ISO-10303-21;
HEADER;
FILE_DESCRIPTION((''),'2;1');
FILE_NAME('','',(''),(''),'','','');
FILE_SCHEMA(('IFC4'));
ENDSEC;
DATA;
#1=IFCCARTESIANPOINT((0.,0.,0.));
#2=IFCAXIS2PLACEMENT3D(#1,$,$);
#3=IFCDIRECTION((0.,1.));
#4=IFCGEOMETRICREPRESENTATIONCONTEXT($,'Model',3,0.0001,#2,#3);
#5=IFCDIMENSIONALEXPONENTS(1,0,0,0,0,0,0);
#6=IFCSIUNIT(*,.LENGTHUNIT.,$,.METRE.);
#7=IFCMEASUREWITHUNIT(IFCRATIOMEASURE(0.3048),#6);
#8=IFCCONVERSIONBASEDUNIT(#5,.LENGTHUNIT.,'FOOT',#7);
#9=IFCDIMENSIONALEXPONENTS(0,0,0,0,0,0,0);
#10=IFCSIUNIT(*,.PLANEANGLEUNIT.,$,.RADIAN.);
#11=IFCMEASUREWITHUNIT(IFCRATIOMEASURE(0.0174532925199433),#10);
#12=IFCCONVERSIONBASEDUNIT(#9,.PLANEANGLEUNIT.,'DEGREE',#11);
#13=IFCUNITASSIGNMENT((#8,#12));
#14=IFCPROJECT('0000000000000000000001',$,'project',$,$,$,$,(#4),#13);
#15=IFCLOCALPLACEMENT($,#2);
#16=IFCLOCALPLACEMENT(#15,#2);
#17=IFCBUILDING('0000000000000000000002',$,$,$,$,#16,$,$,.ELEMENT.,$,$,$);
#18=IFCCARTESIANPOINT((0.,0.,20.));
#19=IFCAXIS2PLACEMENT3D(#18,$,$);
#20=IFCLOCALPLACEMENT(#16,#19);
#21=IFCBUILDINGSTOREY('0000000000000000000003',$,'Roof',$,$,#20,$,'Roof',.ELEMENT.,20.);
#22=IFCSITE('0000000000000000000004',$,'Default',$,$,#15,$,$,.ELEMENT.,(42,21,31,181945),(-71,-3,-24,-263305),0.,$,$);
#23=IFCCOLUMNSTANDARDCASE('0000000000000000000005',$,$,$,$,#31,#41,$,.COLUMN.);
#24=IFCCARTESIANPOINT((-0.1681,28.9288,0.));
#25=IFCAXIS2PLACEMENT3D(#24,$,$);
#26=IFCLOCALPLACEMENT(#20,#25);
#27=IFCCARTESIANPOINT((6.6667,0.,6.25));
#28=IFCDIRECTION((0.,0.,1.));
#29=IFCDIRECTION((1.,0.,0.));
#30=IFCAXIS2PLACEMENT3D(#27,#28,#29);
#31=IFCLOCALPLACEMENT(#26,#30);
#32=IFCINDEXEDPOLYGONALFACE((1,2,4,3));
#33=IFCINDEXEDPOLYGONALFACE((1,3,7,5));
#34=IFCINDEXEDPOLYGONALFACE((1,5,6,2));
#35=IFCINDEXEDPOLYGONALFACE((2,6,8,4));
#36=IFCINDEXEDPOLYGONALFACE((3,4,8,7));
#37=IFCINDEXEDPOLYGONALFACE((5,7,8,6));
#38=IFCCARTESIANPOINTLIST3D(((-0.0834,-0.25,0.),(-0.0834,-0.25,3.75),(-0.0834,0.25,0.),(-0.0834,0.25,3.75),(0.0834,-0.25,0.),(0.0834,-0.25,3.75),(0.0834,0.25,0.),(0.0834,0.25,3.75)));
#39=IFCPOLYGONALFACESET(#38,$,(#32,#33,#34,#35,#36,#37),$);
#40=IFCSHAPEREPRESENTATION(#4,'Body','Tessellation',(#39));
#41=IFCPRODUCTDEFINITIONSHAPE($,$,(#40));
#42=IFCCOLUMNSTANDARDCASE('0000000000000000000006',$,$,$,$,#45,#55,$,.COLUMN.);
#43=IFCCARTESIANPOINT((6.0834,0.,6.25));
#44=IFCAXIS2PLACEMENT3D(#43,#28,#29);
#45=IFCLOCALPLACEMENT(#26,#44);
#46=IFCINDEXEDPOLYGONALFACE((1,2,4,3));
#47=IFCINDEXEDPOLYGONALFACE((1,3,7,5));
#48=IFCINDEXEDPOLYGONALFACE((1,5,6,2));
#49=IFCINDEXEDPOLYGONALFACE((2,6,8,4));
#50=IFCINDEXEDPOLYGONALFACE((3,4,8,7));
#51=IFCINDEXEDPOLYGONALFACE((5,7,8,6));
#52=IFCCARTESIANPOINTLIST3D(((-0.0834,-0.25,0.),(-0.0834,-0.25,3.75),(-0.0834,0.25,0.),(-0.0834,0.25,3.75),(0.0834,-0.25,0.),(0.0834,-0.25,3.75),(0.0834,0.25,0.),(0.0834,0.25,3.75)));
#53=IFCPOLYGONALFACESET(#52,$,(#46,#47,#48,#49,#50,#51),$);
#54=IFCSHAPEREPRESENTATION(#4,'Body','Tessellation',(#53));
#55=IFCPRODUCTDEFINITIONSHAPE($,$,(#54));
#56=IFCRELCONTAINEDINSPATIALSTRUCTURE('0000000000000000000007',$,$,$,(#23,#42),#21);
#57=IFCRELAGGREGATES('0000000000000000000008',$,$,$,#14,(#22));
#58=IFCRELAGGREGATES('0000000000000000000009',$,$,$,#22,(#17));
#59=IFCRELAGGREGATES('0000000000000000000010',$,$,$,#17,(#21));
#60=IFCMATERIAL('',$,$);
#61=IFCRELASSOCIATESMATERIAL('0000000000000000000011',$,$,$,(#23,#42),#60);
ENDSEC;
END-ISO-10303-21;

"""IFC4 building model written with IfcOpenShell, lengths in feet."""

from ifc_helpers import new_model, entity, si_unit, converted_unit, direction, frame, origin, place, context, project, spatial, rectangle, extrude, material, element, save


model = new_model("IFC4")

# Units and contexts
model_context = context("Model", 3, precision=0.0001, world=origin(), true_north=direction((0.0, 1.0)))
ifc_project = project(units=[converted_unit("LENGTHUNIT", "FOOT", entity("IfcRatioMeasure", 0.3048), si_unit("LENGTHUNIT", "METRE"), dimensions=[1, 0, 0, 0, 0, 0, 0]), converted_unit("PLANEANGLEUNIT", "DEGREE", entity("IfcRatioMeasure", 0.0174532925199433), si_unit("PLANEANGLEUNIT", "RADIAN"), dimensions=[0, 0, 0, 0, 0, 0, 0])], contexts=[model_context])

# Site, building, storey
site_placement = place(None, origin())
site = spatial("IfcSite", under=ifc_project, at=site_placement, Name="Default", CompositionType="ELEMENT", RefLatitude=(42, 21, 31, 181945), RefLongitude=(-71, -3, -24, -263305), RefElevation=0.0)
building_placement = place(site_placement, origin())
building = spatial("IfcBuilding", under=site, at=building_placement, CompositionType="ELEMENT")
storey_placement = place(building_placement, frame((0.0, 0.0, 20.0)))
storey = spatial("IfcBuildingStorey", under=building, at=storey_placement, Name="Roof", LongName="Roof", CompositionType="ELEMENT", Elevation=20.0)

# Columns
ifc_material = material(Name="")
placement = place(storey_placement, frame((-0.1681, 28.9288, 0.0)))
for number, where, z_axis, x_axis in (
    (1, (6.6667, 0.0, 6.25), (0.0, 0.0, 1.0), (1.0, 0.0, 0.0)),
    (2, (6.0834, 0.0, 6.25), (0.0, 0.0, 1.0), (1.0, 0.0, 0.0)),
):
    element("IfcColumnStandardCase", number, at=place(placement, frame(where, z_axis=z_axis, x_axis=x_axis)), inside=storey, material=ifc_material, PredefinedType="COLUMN", context=model_context, shape_type="SweptSolid", body=[
        extrude(rectangle(XDim=0.1667, YDim=0.5), origin(), (0.0, 0.0, 1.0), 3.75),
    ])

save(model, "model.ifc")
